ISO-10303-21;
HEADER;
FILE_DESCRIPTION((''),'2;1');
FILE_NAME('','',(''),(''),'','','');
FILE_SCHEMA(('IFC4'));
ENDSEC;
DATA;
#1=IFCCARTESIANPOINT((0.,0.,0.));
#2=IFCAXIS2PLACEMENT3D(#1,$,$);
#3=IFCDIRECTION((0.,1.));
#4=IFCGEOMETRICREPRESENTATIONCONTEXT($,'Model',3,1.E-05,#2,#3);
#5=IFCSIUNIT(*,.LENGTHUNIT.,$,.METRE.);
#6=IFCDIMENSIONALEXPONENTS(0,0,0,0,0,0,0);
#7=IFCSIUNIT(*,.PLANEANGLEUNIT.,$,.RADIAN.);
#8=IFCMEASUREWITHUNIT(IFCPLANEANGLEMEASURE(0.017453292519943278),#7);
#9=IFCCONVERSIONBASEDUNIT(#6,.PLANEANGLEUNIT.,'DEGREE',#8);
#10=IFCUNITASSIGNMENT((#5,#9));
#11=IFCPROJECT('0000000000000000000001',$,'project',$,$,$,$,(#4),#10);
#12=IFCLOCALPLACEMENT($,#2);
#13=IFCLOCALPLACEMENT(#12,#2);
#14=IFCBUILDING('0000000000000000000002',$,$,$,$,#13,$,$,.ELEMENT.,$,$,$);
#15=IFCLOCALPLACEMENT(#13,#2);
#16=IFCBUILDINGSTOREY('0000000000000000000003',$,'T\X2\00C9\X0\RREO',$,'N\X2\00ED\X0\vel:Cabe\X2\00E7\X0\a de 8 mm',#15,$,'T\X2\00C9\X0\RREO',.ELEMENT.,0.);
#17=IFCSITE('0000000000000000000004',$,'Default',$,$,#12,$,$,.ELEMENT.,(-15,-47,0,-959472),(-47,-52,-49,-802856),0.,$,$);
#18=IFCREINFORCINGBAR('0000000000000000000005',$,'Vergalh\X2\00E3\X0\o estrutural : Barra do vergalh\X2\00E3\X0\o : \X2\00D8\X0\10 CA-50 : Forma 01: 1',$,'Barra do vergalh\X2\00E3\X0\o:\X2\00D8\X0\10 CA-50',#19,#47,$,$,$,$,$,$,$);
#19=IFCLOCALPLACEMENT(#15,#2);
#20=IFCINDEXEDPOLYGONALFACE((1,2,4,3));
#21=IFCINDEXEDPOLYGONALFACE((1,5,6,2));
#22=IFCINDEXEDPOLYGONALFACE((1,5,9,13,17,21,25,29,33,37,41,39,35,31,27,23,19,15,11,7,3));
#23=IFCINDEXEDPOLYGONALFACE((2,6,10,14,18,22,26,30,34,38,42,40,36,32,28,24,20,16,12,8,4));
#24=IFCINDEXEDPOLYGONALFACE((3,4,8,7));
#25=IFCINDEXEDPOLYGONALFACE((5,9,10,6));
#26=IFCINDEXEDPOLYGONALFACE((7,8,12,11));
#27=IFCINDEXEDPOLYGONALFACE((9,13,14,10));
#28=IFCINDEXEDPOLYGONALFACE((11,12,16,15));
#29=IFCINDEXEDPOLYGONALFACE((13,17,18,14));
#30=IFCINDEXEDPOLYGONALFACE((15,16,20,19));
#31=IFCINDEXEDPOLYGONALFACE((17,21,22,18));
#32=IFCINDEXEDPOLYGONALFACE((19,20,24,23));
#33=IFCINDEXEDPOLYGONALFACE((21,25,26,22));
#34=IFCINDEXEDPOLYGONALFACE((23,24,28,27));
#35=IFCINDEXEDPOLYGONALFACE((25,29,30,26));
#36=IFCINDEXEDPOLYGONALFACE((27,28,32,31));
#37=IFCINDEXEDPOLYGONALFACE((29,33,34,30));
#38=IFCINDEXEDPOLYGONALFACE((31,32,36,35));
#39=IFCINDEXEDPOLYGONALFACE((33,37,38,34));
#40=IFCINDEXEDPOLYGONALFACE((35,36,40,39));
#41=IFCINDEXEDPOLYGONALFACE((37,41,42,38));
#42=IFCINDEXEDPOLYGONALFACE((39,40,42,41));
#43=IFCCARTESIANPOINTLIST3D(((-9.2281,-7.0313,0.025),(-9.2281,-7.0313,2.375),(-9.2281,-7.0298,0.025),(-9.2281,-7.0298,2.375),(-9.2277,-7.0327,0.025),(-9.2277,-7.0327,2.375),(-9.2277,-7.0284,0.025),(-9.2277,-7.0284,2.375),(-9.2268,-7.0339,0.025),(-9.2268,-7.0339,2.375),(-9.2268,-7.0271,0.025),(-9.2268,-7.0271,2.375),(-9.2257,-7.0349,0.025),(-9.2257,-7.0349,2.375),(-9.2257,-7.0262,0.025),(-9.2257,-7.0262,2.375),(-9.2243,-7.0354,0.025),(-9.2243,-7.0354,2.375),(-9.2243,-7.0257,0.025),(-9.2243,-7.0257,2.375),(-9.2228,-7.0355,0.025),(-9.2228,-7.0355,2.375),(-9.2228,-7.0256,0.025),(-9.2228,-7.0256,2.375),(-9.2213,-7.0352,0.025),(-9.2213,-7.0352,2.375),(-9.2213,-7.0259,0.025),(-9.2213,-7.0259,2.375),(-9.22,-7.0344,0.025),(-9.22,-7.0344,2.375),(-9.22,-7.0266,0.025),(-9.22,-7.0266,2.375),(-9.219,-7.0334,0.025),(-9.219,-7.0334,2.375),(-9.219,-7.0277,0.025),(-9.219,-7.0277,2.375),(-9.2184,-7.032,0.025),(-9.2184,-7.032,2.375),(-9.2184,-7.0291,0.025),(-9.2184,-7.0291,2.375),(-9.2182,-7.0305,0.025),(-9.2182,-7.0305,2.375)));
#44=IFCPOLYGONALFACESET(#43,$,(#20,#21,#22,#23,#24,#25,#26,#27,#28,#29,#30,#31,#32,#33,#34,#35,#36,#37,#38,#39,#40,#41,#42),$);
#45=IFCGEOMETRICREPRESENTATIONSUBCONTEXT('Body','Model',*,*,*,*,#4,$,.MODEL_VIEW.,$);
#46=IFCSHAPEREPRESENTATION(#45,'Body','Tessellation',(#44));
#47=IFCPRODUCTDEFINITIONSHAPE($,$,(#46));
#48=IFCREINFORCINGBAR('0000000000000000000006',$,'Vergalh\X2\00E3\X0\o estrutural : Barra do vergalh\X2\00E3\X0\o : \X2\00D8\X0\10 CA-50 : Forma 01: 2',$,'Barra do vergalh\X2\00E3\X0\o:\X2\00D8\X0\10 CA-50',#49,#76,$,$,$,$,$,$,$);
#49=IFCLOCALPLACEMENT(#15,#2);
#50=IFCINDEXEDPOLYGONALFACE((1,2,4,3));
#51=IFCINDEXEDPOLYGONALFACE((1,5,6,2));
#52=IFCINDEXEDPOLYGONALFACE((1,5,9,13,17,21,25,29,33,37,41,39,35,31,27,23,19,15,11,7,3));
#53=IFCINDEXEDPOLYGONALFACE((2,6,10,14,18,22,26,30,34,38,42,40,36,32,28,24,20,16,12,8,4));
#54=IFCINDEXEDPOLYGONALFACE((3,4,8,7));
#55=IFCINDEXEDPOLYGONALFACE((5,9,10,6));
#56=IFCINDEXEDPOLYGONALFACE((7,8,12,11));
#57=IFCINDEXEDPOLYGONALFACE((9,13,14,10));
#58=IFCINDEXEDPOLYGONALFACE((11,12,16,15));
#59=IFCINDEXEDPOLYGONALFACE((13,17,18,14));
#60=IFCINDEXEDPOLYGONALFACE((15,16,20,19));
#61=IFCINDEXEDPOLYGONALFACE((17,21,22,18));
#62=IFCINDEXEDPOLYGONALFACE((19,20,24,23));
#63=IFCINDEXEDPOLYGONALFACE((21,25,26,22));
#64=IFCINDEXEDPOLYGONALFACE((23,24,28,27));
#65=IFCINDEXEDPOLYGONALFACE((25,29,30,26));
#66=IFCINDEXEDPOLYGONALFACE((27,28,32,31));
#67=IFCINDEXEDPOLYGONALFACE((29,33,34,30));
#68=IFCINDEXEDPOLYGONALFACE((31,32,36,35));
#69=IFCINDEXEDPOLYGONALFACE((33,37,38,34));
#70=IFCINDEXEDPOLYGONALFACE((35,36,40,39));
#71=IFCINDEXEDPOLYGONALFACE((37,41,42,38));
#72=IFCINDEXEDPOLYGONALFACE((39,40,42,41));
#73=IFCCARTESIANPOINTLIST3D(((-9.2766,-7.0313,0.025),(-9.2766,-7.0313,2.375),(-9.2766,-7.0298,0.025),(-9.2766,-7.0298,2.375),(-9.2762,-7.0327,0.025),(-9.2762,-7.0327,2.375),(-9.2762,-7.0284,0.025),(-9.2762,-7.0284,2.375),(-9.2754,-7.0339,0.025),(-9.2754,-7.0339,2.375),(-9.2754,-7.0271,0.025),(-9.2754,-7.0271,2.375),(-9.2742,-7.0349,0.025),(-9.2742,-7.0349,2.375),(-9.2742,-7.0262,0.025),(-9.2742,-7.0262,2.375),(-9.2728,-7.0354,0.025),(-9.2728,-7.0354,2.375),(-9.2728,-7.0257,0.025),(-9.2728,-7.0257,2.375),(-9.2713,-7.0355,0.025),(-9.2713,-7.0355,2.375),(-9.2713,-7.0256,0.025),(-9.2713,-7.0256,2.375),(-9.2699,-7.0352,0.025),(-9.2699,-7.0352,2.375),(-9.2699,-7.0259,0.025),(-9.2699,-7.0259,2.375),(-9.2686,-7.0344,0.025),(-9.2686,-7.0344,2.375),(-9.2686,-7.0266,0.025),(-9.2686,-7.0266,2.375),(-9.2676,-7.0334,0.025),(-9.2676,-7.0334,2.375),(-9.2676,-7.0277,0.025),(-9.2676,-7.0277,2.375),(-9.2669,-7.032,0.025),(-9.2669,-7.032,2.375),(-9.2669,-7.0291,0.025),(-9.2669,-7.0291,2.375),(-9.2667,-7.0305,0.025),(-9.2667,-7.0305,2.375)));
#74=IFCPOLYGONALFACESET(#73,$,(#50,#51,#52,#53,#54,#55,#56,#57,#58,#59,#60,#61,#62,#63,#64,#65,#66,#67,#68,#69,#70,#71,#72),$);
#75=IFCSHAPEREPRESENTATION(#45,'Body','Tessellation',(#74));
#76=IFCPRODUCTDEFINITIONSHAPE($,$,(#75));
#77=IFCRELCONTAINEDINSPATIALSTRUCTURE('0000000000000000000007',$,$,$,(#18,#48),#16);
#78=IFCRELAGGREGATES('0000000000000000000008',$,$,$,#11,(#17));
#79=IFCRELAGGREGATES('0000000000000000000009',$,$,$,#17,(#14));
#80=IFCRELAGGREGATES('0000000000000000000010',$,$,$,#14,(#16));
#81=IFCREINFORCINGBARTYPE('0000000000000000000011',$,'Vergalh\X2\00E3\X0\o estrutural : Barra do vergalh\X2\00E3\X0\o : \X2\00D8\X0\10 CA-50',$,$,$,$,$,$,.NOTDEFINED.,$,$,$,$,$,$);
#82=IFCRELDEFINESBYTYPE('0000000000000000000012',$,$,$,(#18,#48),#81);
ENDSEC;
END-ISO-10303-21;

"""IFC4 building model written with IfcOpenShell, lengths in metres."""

from ifc_helpers import new_model, entity, si_unit, converted_unit, direction, origin, place, context, subcontext, project, spatial, type_object, element, save


model = new_model("IFC4")

# Units and contexts
model_context = context("Model", 3, precision=1e-05, world=origin(), true_north=direction((0.0, 1.0)))
body_context = subcontext(model_context, "Body", "Model", "MODEL_VIEW")
ifc_project = project(units=[si_unit("LENGTHUNIT", "METRE"), converted_unit("PLANEANGLEUNIT", "DEGREE", entity("IfcPlaneAngleMeasure", 0.017453292519943278), si_unit("PLANEANGLEUNIT", "RADIAN"), dimensions=[0, 0, 0, 0, 0, 0, 0])], contexts=[model_context])

# Site, building, storey
site_placement = place(None, origin())
site = spatial("IfcSite", under=ifc_project, at=site_placement, Name="Default", CompositionType="ELEMENT", RefLatitude=(-15, -47, 0, -959472), RefLongitude=(-47, -52, -49, -802856), RefElevation=0.0)
building_placement = place(site_placement, origin())
building = spatial("IfcBuilding", under=site, at=building_placement, CompositionType="ELEMENT")
storey_placement = place(building_placement, origin())
storey = spatial("IfcBuildingStorey", under=building, at=storey_placement, Name="TÉRREO", ObjectType="Nível:Cabeça de 8 mm", LongName="TÉRREO", CompositionType="ELEMENT", Elevation=0.0)

# Reinforcing bars
reinforcing_bar_type_1 = type_object("IfcReinforcingBarType", Name="Vergalhão estrutural : Barra do vergalhão : Ø10 CA-50", PredefinedType="NOTDEFINED")
reinforcing_bar_1_placement = place(storey_placement, origin())
element("IfcReinforcingBar", 1, at=reinforcing_bar_1_placement, inside=storey, type_object=reinforcing_bar_type_1, Name="Vergalhão estrutural : Barra do vergalhão : Ø10 CA-50 : Forma 01: 1", ObjectType="Barra do vergalhão:Ø10 CA-50", context=body_context, shape_type="AdvancedSweptSolid", body=[
    entity("IfcSweptDiskSolid", entity("IfcIndexedPolyCurve", entity("IfcCartesianPointList3D", [[-9.2232, -7.0305, 0.025], [-9.2232, -7.0305, 2.375]]), None, False), 0.005, None, 0.0, 1.0),
])
reinforcing_bar_2_placement = place(storey_placement, origin())
element("IfcReinforcingBar", 2, at=reinforcing_bar_2_placement, inside=storey, type_object=reinforcing_bar_type_1, Name="Vergalhão estrutural : Barra do vergalhão : Ø10 CA-50 : Forma 01: 2", ObjectType="Barra do vergalhão:Ø10 CA-50", context=body_context, shape_type="AdvancedSweptSolid", body=[
    entity("IfcSweptDiskSolid", entity("IfcIndexedPolyCurve", entity("IfcCartesianPointList3D", [[-9.2717, -7.0305, 0.025], [-9.2717, -7.0305, 2.375]]), None, False), 0.005, None, 0.0, 1.0),
])

save(model, "model.ifc")
